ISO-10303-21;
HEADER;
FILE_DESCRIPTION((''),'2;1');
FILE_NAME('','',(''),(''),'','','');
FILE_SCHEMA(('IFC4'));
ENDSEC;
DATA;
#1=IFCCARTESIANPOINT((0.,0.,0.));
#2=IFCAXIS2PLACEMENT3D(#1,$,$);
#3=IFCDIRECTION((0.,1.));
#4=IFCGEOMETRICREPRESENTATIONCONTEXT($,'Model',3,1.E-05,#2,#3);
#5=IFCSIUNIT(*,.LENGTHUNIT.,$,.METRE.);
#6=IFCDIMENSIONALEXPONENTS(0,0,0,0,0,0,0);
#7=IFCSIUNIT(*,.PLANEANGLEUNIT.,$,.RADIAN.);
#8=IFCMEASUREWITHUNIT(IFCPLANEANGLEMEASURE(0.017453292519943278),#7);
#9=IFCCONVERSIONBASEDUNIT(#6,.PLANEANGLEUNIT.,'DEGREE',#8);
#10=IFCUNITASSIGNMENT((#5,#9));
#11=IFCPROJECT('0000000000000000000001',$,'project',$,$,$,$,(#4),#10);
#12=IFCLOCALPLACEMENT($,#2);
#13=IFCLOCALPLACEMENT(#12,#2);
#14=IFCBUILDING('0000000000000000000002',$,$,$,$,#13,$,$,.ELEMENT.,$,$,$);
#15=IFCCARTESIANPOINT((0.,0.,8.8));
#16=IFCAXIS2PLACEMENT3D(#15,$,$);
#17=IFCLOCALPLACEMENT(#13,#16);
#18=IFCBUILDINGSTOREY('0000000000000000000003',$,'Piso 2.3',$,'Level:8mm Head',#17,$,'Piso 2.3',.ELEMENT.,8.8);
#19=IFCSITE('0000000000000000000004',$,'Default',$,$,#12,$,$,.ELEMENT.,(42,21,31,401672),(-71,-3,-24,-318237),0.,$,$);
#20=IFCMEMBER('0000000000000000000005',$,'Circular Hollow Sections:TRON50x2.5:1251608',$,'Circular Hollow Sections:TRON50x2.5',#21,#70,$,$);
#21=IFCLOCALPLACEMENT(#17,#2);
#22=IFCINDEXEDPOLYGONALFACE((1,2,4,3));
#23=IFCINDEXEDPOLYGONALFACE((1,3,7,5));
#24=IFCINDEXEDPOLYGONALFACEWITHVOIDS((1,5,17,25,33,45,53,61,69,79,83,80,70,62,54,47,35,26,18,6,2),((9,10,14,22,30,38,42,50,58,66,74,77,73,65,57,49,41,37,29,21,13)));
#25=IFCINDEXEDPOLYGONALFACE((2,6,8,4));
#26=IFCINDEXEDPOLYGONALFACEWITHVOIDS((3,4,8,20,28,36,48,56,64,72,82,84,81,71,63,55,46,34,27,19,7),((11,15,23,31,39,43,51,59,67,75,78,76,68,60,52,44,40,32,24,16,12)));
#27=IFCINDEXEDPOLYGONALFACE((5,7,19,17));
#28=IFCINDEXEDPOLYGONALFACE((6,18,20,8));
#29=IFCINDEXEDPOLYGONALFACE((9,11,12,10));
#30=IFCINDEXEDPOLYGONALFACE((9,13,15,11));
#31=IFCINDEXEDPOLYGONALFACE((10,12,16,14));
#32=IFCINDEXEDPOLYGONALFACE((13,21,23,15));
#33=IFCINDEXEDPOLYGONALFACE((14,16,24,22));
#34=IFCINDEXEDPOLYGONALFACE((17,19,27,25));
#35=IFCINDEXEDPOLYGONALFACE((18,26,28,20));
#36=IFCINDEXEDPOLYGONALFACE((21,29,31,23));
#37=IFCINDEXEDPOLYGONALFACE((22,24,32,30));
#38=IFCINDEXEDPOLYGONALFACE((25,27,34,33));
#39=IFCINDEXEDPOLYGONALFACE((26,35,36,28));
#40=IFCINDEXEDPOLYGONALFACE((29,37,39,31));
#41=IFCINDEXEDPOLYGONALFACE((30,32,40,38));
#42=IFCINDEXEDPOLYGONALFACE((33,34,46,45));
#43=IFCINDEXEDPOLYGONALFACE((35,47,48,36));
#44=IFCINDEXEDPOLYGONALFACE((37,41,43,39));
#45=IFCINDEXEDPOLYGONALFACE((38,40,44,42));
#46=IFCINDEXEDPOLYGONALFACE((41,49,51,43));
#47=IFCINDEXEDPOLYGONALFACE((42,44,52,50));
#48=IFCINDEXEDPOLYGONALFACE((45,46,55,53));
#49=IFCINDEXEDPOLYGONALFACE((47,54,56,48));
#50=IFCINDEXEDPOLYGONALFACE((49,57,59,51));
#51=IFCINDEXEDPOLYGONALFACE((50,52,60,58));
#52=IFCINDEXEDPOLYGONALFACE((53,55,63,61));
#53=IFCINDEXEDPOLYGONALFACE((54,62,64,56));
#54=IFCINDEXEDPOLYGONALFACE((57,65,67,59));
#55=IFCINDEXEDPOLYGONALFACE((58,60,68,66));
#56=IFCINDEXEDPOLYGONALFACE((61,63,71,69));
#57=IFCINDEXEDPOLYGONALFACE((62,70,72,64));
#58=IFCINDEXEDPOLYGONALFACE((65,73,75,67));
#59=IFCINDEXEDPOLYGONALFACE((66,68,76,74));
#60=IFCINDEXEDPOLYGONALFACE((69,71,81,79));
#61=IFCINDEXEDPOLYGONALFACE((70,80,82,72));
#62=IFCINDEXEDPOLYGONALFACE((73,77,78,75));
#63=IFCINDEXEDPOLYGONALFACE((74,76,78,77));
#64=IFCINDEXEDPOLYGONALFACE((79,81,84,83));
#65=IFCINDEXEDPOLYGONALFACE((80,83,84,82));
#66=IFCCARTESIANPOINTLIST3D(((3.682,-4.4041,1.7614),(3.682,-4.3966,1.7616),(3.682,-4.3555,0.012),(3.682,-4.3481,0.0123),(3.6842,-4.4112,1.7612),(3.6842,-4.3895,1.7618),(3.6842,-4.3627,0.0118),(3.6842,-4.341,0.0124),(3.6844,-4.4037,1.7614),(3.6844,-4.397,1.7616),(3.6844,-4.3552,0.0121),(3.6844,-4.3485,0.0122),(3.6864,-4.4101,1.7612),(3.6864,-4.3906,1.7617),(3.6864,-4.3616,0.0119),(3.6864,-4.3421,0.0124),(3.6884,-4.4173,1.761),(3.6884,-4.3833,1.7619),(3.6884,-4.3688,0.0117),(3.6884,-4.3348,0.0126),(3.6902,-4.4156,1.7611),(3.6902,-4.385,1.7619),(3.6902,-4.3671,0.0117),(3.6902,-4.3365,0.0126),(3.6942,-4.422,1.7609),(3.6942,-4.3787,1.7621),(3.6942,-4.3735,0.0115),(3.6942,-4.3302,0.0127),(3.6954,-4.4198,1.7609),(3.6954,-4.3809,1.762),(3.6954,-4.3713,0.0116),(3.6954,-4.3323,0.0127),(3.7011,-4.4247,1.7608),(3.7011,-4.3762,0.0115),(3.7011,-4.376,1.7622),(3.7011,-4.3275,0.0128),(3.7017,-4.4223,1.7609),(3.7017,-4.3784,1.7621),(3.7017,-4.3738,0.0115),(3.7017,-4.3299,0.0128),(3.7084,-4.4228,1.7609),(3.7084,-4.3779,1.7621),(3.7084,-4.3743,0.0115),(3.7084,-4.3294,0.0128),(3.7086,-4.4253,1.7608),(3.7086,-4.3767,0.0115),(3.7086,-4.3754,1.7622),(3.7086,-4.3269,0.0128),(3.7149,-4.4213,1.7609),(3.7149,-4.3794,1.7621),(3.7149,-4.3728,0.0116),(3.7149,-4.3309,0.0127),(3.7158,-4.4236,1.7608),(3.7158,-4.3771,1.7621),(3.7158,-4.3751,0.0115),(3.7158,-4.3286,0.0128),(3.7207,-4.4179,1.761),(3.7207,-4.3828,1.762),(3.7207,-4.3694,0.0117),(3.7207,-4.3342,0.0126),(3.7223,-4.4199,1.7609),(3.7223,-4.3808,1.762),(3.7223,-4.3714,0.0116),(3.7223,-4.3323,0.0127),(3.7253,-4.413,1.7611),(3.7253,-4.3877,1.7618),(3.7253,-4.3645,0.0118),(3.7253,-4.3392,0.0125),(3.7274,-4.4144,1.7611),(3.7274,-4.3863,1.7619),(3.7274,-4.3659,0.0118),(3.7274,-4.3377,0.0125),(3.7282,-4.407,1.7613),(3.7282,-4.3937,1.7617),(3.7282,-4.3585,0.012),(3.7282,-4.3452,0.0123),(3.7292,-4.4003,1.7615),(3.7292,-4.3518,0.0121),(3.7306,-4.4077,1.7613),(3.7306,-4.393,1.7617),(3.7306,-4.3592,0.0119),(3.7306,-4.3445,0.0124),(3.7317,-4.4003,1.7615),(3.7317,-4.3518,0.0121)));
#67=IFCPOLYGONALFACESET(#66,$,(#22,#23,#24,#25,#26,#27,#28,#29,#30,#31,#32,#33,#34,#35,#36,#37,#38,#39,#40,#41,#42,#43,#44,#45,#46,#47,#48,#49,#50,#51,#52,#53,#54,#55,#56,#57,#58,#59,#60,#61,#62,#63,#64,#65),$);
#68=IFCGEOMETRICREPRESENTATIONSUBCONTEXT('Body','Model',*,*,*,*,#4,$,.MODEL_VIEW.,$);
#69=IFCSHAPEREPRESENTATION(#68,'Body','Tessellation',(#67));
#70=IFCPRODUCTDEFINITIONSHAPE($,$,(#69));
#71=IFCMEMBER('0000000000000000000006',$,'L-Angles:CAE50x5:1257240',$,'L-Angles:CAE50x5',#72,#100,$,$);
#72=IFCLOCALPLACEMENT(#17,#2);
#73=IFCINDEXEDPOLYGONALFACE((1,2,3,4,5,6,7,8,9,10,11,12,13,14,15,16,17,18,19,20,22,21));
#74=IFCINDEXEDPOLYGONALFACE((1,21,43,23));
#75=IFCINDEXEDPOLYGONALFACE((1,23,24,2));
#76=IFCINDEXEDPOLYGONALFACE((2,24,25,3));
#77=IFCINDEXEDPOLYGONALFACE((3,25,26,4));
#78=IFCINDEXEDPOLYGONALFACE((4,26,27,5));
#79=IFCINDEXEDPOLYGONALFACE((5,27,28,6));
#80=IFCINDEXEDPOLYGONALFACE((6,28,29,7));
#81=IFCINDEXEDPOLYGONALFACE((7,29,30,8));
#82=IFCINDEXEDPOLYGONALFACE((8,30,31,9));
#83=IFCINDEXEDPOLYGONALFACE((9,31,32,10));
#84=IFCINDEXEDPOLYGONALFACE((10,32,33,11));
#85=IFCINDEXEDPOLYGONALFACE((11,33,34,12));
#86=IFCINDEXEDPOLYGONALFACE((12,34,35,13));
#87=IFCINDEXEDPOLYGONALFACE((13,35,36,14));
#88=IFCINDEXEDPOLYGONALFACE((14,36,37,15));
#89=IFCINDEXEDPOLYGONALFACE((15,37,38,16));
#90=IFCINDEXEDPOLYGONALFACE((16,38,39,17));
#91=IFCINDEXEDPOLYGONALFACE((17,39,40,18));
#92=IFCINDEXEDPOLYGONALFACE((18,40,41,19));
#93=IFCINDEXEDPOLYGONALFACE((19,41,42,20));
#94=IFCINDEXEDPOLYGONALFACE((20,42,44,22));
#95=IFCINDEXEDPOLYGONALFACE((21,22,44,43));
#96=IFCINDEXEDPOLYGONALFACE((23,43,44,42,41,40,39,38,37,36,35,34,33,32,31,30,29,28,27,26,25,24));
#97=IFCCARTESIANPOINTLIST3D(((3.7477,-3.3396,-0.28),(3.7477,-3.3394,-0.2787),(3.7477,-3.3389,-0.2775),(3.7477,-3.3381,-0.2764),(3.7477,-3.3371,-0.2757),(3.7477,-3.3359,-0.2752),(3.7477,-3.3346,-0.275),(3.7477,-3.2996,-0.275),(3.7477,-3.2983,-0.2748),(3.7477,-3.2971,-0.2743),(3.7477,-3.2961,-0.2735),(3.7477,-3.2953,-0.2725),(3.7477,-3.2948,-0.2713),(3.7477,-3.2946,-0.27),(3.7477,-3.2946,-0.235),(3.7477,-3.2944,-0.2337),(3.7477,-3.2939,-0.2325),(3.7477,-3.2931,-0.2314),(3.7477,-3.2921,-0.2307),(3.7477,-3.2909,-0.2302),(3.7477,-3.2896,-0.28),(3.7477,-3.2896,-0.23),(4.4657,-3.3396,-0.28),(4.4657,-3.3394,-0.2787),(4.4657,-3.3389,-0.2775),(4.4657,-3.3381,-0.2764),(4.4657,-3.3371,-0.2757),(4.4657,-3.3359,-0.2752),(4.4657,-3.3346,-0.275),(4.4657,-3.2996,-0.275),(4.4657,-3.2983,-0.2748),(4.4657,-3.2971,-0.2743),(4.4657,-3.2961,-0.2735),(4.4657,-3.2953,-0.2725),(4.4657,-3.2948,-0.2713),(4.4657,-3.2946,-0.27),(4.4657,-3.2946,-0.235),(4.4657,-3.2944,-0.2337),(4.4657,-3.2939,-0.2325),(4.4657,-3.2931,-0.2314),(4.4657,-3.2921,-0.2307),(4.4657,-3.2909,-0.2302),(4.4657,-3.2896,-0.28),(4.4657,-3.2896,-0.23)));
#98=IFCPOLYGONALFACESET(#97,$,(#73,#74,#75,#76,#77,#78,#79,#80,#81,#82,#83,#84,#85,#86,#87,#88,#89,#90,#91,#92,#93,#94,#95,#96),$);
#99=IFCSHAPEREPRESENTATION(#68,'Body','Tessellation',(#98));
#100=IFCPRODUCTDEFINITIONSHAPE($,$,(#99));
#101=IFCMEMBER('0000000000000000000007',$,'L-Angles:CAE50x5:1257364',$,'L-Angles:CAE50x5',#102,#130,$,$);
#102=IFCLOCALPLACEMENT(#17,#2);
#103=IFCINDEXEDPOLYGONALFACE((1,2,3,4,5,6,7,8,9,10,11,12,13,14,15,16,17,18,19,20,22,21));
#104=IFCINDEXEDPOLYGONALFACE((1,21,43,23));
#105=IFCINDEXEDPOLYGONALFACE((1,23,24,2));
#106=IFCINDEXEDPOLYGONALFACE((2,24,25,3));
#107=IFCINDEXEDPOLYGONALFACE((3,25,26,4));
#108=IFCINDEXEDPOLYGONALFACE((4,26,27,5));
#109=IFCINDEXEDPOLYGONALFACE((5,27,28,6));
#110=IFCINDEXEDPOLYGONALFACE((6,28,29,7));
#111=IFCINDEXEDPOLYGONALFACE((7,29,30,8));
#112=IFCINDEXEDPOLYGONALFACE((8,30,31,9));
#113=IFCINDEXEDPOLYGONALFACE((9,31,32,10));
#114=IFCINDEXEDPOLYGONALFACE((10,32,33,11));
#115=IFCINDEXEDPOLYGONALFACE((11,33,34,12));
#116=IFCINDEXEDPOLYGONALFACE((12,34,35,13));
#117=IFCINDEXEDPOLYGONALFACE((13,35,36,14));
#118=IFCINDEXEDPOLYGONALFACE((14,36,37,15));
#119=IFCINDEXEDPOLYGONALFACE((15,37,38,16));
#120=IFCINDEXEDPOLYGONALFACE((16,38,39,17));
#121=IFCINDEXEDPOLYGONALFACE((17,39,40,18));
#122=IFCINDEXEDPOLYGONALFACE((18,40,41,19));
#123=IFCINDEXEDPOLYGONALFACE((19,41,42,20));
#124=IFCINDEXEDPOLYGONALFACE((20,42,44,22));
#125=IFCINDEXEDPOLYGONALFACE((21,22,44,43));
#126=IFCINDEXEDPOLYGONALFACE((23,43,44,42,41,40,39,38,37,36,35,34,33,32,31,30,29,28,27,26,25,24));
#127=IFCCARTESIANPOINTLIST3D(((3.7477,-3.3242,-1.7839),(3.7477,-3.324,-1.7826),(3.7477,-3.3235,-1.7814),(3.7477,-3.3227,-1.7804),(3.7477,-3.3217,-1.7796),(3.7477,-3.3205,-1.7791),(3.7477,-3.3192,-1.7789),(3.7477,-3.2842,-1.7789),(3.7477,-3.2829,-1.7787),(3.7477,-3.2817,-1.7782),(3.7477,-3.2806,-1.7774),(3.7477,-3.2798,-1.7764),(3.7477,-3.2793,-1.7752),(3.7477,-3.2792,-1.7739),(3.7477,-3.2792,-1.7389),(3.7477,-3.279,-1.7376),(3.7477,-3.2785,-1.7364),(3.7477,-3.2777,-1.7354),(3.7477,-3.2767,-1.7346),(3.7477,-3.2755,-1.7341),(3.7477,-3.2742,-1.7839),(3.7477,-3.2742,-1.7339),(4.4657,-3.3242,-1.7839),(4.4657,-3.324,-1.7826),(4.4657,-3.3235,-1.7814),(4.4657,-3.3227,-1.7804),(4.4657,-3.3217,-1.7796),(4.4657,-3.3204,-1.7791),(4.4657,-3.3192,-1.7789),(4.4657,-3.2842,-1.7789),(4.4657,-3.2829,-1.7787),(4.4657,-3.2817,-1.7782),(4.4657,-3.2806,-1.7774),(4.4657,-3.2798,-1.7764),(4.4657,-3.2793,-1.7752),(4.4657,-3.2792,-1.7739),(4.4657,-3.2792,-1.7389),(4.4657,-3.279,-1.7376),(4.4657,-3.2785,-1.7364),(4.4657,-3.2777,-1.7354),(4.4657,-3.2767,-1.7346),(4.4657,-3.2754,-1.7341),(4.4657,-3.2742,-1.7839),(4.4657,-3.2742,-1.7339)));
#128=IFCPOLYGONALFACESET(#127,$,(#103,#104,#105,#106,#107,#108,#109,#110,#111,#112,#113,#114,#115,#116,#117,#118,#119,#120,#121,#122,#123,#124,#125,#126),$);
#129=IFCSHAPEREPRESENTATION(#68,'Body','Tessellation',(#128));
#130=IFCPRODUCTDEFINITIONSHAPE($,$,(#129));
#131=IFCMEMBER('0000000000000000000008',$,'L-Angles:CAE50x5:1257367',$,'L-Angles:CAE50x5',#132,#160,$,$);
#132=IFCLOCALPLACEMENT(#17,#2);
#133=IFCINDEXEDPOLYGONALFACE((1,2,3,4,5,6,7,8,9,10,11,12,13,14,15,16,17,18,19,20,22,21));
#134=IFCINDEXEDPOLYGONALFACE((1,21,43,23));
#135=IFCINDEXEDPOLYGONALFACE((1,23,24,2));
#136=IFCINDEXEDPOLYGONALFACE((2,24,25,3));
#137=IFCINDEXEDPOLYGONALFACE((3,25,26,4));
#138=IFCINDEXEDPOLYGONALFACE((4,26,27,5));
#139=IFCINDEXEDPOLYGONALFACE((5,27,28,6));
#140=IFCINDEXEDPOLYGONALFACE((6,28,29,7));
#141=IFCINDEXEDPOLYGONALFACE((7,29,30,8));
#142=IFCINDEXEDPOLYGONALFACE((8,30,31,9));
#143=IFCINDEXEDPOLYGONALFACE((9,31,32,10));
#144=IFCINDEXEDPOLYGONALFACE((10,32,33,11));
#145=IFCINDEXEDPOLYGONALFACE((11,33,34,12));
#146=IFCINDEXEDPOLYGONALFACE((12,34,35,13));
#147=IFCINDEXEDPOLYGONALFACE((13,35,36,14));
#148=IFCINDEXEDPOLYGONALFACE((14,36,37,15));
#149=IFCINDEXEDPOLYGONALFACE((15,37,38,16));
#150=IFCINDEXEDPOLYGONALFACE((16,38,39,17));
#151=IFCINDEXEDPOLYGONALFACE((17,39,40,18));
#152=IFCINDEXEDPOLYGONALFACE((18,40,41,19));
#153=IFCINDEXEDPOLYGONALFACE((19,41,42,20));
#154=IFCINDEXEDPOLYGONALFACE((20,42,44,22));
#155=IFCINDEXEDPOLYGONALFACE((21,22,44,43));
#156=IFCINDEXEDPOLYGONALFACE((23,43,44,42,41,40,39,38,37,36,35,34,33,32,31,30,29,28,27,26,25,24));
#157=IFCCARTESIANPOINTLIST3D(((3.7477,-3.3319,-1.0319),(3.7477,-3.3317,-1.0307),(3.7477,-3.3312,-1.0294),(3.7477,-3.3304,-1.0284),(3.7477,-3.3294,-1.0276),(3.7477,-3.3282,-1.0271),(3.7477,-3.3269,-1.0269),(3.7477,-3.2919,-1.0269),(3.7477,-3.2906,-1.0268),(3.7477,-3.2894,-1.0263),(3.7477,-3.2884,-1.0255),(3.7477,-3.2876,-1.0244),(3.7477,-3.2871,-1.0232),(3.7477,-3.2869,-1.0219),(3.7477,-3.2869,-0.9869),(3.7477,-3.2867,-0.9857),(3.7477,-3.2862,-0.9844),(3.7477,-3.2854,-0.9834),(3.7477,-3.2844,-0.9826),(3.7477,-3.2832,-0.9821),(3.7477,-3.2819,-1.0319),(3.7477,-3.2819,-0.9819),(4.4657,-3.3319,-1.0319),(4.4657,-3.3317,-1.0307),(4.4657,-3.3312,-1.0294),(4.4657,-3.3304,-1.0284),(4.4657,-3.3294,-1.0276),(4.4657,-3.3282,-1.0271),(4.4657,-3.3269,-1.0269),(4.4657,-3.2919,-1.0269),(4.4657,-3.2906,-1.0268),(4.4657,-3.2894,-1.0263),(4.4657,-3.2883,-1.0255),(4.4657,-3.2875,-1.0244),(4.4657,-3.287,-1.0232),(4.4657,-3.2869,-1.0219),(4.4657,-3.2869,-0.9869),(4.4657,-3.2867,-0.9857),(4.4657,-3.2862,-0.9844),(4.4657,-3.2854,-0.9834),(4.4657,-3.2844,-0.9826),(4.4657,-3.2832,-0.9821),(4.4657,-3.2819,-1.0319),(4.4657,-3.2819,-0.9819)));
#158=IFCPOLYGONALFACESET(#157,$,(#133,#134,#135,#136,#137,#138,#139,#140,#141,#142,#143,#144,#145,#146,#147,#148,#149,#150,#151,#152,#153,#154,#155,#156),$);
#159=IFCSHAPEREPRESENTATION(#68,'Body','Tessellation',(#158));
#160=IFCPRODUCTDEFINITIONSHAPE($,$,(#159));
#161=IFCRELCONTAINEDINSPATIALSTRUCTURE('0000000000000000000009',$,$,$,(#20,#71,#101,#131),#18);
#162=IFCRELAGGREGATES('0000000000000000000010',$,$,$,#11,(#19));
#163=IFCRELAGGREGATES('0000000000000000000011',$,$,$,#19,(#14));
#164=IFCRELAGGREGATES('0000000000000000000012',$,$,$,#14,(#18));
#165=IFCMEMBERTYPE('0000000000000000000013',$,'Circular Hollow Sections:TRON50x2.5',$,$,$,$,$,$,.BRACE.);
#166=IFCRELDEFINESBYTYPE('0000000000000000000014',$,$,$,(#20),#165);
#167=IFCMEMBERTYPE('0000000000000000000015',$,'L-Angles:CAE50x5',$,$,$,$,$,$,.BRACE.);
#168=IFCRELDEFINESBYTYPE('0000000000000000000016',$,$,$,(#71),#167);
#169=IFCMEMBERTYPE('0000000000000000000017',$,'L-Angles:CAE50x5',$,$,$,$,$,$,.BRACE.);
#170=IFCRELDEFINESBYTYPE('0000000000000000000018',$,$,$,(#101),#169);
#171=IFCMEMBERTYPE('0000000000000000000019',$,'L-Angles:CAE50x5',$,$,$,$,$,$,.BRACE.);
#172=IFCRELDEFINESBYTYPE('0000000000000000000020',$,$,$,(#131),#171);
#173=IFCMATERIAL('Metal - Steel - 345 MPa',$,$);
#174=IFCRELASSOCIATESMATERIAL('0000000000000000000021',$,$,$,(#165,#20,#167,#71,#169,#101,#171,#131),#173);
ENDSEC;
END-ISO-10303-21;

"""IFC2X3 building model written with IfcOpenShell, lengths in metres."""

from ifc_helpers import new_model, entity, si_unit, converted_unit, direction, frame, frame_2d, origin, place, context, subcontext, project, spatial, polyline, circle_curve, parameter, trimmed, segment, composite_curve, hollow_circle, outline, extrude, source, transform, mapped, material, type_object, type_shapes, element, save


model = new_model("IFC2X3")

# Units and contexts
model_context = context("Model", 3, precision=1e-05, world=origin(), true_north=direction((0.0, 1.0)))
body_context = subcontext(model_context, "Body", "Model", "MODEL_VIEW")
ifc_project = project(units=[si_unit("LENGTHUNIT", "METRE"), converted_unit("PLANEANGLEUNIT", "DEGREE", entity("IfcPlaneAngleMeasure", 0.017453292519943278), si_unit("PLANEANGLEUNIT", "RADIAN"), dimensions=[0, 0, 0, 0, 0, 0, 0])], contexts=[model_context])

# Site, building, storey
site_placement = place(None, origin())
site = spatial("IfcSite", under=ifc_project, at=site_placement, Name="Default", CompositionType="ELEMENT", RefLatitude=(42, 21, 31, 401672), RefLongitude=(-71, -3, -24, -318237), RefElevation=0.0)
building_placement = place(site_placement, origin())
building = spatial("IfcBuilding", under=site, at=building_placement, CompositionType="ELEMENT")
storey_placement = place(building_placement, frame((0.0, 0.0, 8.8)))
storey = spatial("IfcBuildingStorey", under=building, at=storey_placement, Name="Piso 2.3", ObjectType="Level:8mm Head", LongName="Piso 2.3", CompositionType="ELEMENT", Elevation=8.8)

# Shared definitions
ifc_material_1 = material(Name="Metal - Steel - 345 MPa")

# Members
member_type_1 = type_object("IfcMemberType", Name="Circular Hollow Sections:TRON50x2.5", PredefinedType="BRACE", material=ifc_material_1)
shared_shape_1 = source(origin(), body_context, "Body", "SweptSolid", [
    extrude(hollow_circle(Radius=0.025, WallThickness=0.0025, at=frame_2d((0.0, 0.0), x_axis=(1.0, 0.0))), frame((-0.8875, 0.0, 0.0), z_axis=(1.0, 0.0, 0.0), x_axis=(0.0, 1.0, 0.0)), (0.0, 0.0, 1.0), 1.75),
])
type_shapes(member_type_1, [shared_shape_1])
member_1_placement = place(storey_placement, frame((3.7067, -4.3764, 0.8993), z_axis=(0.0, 0.999616, 0.027721), x_axis=(0.0, -0.027721, 0.999616)))
element("IfcMember", 1, at=member_1_placement, inside=storey, type_object=member_type_1, material=ifc_material_1, Name="Circular Hollow Sections:TRON50x2.5:1251608", ObjectType="Circular Hollow Sections:TRON50x2.5", context=body_context, shape_type="MappedRepresentation", body=[
    mapped(shared_shape_1, transform((0.0, 0.0, 0.0), scale=1.0)),
])
member_type_2 = type_object("IfcMemberType", Name="L-Angles:CAE50x5", PredefinedType="BRACE", material=ifc_material_1)
shared_shape_2 = source(origin(), body_context, "Body", "SweptSolid", [
    extrude(outline(composite_curve([segment(polyline([(-0.0164, -0.0164), (0.0336, -0.0164)]), True, "CONTINUOUS"), segment(trimmed(circle_curve(frame_2d((0.0286, -0.0164), x_axis=(1.0, 0.0)), 0.005), [parameter(0.0)], [parameter(90.0)], True, "PARAMETER"), True, "CONTINUOUS"), segment(polyline([(0.0286, -0.0114), (-0.0064, -0.0114)]), True, "CONTINUOUS"), segment(trimmed(circle_curve(frame_2d((-0.0064, -0.0064), x_axis=(1.0, 0.0)), 0.005), [parameter(180.0)], [parameter(270.0)], True, "PARAMETER"), False, "CONTINUOUS"), segment(polyline([(-0.0114, -0.0064), (-0.0114, 0.0286)]), True, "CONTINUOUS"), segment(trimmed(circle_curve(frame_2d((-0.0164, 0.0286), x_axis=(1.0, 0.0)), 0.005), [parameter(0.0)], [parameter(90.0)], True, "PARAMETER"), True, "CONTINUOUS"), segment(polyline([(-0.0164, 0.0336), (-0.0164, -0.0164)]), True, "CONTINUOUS")], self_intersect=False)), frame((-0.359, -0.0024, -0.0024), z_axis=(1.0, 0.0, 0.0), x_axis=(0.0, -1.0, 0.0)), (0.0, 0.0, 1.0), 0.718),
])
type_shapes(member_type_2, [shared_shape_2])
member_2_placement = place(storey_placement, frame((4.1067, -3.3036, -0.266), z_axis=(-0.000006, 1.0, 0.0), x_axis=(1.0, 0.000006, 0.0)))
element("IfcMember", 2, at=member_2_placement, inside=storey, type_object=member_type_2, material=ifc_material_1, Name="L-Angles:CAE50x5:1257240", ObjectType="L-Angles:CAE50x5", context=body_context, shape_type="MappedRepresentation", body=[
    mapped(shared_shape_2, transform((0.0, 0.0, 0.0), scale=1.0)),
])
member_type_3 = type_object("IfcMemberType", Name="L-Angles:CAE50x5", PredefinedType="BRACE", material=ifc_material_1)
shared_shape_3 = source(origin(), body_context, "Body", "SweptSolid", [
    extrude(outline(composite_curve([segment(polyline([(-0.0164, -0.0164), (0.0336, -0.0164)]), True, "CONTINUOUS"), segment(trimmed(circle_curve(frame_2d((0.0286, -0.0164), x_axis=(1.0, 0.0)), 0.005), [parameter(0.0)], [parameter(90.0)], True, "PARAMETER"), True, "CONTINUOUS"), segment(polyline([(0.0286, -0.0114), (-0.0064, -0.0114)]), True, "CONTINUOUS"), segment(trimmed(circle_curve(frame_2d((-0.0064, -0.0064), x_axis=(1.0, 0.0)), 0.005), [parameter(180.0)], [parameter(270.0)], True, "PARAMETER"), False, "CONTINUOUS"), segment(polyline([(-0.0114, -0.0064), (-0.0114, 0.0286)]), True, "CONTINUOUS"), segment(trimmed(circle_curve(frame_2d((-0.0164, 0.0286), x_axis=(1.0, 0.0)), 0.005), [parameter(0.0)], [parameter(90.0)], True, "PARAMETER"), True, "CONTINUOUS"), segment(polyline([(-0.0164, 0.0336), (-0.0164, -0.0164)]), True, "CONTINUOUS")], self_intersect=False)), frame((-0.359, -0.0024, -0.0024), z_axis=(1.0, 0.0, 0.0), x_axis=(0.0, -1.0, 0.0)), (0.0, 0.0, 1.0), 0.718),
])
type_shapes(member_type_3, [shared_shape_3])
member_3_placement = place(storey_placement, frame((4.1067, -3.2882, -1.7699), z_axis=(-0.000041, 1.0, 0.0), x_axis=(1.0, 0.000041, 0.0)))
element("IfcMember", 3, at=member_3_placement, inside=storey, type_object=member_type_3, material=ifc_material_1, Name="L-Angles:CAE50x5:1257364", ObjectType="L-Angles:CAE50x5", context=body_context, shape_type="MappedRepresentation", body=[
    mapped(shared_shape_3, transform((0.0, 0.0, 0.0), scale=1.0)),
])
member_type_4 = type_object("IfcMemberType", Name="L-Angles:CAE50x5", PredefinedType="BRACE", material=ifc_material_1)
shared_shape_4 = source(origin(), body_context, "Body", "SweptSolid", [
    extrude(outline(composite_curve([segment(polyline([(-0.0164, -0.0164), (0.0336, -0.0164)]), True, "CONTINUOUS"), segment(trimmed(circle_curve(frame_2d((0.0286, -0.0164), x_axis=(1.0, 0.0)), 0.005), [parameter(0.0)], [parameter(90.0)], True, "PARAMETER"), True, "CONTINUOUS"), segment(polyline([(0.0286, -0.0114), (-0.0064, -0.0114)]), True, "CONTINUOUS"), segment(trimmed(circle_curve(frame_2d((-0.0064, -0.0064), x_axis=(1.0, 0.0)), 0.005), [parameter(180.0)], [parameter(270.0)], True, "PARAMETER"), False, "CONTINUOUS"), segment(polyline([(-0.0114, -0.0064), (-0.0114, 0.0286)]), True, "CONTINUOUS"), segment(trimmed(circle_curve(frame_2d((-0.0164, 0.0286), x_axis=(1.0, 0.0)), 0.005), [parameter(0.0)], [parameter(90.0)], True, "PARAMETER"), True, "CONTINUOUS"), segment(polyline([(-0.0164, 0.0336), (-0.0164, -0.0164)]), True, "CONTINUOUS")], self_intersect=False)), frame((-0.359, -0.0024, -0.0024), z_axis=(1.0, 0.0, 0.0), x_axis=(0.0, -1.0, 0.0)), (0.0, 0.0, 1.0), 0.718),
])
type_shapes(member_type_4, [shared_shape_4])
member_4_placement = place(storey_placement, frame((4.1067, -3.2959, -1.0179), z_axis=(-0.000024, 1.0, 0.0), x_axis=(1.0, 0.000024, 0.0)))
element("IfcMember", 4, at=member_4_placement, inside=storey, type_object=member_type_4, material=ifc_material_1, Name="L-Angles:CAE50x5:1257367", ObjectType="L-Angles:CAE50x5", context=body_context, shape_type="MappedRepresentation", body=[
    mapped(shared_shape_4, transform((0.0, 0.0, 0.0), scale=1.0)),
])

save(model, "model.ifc")
